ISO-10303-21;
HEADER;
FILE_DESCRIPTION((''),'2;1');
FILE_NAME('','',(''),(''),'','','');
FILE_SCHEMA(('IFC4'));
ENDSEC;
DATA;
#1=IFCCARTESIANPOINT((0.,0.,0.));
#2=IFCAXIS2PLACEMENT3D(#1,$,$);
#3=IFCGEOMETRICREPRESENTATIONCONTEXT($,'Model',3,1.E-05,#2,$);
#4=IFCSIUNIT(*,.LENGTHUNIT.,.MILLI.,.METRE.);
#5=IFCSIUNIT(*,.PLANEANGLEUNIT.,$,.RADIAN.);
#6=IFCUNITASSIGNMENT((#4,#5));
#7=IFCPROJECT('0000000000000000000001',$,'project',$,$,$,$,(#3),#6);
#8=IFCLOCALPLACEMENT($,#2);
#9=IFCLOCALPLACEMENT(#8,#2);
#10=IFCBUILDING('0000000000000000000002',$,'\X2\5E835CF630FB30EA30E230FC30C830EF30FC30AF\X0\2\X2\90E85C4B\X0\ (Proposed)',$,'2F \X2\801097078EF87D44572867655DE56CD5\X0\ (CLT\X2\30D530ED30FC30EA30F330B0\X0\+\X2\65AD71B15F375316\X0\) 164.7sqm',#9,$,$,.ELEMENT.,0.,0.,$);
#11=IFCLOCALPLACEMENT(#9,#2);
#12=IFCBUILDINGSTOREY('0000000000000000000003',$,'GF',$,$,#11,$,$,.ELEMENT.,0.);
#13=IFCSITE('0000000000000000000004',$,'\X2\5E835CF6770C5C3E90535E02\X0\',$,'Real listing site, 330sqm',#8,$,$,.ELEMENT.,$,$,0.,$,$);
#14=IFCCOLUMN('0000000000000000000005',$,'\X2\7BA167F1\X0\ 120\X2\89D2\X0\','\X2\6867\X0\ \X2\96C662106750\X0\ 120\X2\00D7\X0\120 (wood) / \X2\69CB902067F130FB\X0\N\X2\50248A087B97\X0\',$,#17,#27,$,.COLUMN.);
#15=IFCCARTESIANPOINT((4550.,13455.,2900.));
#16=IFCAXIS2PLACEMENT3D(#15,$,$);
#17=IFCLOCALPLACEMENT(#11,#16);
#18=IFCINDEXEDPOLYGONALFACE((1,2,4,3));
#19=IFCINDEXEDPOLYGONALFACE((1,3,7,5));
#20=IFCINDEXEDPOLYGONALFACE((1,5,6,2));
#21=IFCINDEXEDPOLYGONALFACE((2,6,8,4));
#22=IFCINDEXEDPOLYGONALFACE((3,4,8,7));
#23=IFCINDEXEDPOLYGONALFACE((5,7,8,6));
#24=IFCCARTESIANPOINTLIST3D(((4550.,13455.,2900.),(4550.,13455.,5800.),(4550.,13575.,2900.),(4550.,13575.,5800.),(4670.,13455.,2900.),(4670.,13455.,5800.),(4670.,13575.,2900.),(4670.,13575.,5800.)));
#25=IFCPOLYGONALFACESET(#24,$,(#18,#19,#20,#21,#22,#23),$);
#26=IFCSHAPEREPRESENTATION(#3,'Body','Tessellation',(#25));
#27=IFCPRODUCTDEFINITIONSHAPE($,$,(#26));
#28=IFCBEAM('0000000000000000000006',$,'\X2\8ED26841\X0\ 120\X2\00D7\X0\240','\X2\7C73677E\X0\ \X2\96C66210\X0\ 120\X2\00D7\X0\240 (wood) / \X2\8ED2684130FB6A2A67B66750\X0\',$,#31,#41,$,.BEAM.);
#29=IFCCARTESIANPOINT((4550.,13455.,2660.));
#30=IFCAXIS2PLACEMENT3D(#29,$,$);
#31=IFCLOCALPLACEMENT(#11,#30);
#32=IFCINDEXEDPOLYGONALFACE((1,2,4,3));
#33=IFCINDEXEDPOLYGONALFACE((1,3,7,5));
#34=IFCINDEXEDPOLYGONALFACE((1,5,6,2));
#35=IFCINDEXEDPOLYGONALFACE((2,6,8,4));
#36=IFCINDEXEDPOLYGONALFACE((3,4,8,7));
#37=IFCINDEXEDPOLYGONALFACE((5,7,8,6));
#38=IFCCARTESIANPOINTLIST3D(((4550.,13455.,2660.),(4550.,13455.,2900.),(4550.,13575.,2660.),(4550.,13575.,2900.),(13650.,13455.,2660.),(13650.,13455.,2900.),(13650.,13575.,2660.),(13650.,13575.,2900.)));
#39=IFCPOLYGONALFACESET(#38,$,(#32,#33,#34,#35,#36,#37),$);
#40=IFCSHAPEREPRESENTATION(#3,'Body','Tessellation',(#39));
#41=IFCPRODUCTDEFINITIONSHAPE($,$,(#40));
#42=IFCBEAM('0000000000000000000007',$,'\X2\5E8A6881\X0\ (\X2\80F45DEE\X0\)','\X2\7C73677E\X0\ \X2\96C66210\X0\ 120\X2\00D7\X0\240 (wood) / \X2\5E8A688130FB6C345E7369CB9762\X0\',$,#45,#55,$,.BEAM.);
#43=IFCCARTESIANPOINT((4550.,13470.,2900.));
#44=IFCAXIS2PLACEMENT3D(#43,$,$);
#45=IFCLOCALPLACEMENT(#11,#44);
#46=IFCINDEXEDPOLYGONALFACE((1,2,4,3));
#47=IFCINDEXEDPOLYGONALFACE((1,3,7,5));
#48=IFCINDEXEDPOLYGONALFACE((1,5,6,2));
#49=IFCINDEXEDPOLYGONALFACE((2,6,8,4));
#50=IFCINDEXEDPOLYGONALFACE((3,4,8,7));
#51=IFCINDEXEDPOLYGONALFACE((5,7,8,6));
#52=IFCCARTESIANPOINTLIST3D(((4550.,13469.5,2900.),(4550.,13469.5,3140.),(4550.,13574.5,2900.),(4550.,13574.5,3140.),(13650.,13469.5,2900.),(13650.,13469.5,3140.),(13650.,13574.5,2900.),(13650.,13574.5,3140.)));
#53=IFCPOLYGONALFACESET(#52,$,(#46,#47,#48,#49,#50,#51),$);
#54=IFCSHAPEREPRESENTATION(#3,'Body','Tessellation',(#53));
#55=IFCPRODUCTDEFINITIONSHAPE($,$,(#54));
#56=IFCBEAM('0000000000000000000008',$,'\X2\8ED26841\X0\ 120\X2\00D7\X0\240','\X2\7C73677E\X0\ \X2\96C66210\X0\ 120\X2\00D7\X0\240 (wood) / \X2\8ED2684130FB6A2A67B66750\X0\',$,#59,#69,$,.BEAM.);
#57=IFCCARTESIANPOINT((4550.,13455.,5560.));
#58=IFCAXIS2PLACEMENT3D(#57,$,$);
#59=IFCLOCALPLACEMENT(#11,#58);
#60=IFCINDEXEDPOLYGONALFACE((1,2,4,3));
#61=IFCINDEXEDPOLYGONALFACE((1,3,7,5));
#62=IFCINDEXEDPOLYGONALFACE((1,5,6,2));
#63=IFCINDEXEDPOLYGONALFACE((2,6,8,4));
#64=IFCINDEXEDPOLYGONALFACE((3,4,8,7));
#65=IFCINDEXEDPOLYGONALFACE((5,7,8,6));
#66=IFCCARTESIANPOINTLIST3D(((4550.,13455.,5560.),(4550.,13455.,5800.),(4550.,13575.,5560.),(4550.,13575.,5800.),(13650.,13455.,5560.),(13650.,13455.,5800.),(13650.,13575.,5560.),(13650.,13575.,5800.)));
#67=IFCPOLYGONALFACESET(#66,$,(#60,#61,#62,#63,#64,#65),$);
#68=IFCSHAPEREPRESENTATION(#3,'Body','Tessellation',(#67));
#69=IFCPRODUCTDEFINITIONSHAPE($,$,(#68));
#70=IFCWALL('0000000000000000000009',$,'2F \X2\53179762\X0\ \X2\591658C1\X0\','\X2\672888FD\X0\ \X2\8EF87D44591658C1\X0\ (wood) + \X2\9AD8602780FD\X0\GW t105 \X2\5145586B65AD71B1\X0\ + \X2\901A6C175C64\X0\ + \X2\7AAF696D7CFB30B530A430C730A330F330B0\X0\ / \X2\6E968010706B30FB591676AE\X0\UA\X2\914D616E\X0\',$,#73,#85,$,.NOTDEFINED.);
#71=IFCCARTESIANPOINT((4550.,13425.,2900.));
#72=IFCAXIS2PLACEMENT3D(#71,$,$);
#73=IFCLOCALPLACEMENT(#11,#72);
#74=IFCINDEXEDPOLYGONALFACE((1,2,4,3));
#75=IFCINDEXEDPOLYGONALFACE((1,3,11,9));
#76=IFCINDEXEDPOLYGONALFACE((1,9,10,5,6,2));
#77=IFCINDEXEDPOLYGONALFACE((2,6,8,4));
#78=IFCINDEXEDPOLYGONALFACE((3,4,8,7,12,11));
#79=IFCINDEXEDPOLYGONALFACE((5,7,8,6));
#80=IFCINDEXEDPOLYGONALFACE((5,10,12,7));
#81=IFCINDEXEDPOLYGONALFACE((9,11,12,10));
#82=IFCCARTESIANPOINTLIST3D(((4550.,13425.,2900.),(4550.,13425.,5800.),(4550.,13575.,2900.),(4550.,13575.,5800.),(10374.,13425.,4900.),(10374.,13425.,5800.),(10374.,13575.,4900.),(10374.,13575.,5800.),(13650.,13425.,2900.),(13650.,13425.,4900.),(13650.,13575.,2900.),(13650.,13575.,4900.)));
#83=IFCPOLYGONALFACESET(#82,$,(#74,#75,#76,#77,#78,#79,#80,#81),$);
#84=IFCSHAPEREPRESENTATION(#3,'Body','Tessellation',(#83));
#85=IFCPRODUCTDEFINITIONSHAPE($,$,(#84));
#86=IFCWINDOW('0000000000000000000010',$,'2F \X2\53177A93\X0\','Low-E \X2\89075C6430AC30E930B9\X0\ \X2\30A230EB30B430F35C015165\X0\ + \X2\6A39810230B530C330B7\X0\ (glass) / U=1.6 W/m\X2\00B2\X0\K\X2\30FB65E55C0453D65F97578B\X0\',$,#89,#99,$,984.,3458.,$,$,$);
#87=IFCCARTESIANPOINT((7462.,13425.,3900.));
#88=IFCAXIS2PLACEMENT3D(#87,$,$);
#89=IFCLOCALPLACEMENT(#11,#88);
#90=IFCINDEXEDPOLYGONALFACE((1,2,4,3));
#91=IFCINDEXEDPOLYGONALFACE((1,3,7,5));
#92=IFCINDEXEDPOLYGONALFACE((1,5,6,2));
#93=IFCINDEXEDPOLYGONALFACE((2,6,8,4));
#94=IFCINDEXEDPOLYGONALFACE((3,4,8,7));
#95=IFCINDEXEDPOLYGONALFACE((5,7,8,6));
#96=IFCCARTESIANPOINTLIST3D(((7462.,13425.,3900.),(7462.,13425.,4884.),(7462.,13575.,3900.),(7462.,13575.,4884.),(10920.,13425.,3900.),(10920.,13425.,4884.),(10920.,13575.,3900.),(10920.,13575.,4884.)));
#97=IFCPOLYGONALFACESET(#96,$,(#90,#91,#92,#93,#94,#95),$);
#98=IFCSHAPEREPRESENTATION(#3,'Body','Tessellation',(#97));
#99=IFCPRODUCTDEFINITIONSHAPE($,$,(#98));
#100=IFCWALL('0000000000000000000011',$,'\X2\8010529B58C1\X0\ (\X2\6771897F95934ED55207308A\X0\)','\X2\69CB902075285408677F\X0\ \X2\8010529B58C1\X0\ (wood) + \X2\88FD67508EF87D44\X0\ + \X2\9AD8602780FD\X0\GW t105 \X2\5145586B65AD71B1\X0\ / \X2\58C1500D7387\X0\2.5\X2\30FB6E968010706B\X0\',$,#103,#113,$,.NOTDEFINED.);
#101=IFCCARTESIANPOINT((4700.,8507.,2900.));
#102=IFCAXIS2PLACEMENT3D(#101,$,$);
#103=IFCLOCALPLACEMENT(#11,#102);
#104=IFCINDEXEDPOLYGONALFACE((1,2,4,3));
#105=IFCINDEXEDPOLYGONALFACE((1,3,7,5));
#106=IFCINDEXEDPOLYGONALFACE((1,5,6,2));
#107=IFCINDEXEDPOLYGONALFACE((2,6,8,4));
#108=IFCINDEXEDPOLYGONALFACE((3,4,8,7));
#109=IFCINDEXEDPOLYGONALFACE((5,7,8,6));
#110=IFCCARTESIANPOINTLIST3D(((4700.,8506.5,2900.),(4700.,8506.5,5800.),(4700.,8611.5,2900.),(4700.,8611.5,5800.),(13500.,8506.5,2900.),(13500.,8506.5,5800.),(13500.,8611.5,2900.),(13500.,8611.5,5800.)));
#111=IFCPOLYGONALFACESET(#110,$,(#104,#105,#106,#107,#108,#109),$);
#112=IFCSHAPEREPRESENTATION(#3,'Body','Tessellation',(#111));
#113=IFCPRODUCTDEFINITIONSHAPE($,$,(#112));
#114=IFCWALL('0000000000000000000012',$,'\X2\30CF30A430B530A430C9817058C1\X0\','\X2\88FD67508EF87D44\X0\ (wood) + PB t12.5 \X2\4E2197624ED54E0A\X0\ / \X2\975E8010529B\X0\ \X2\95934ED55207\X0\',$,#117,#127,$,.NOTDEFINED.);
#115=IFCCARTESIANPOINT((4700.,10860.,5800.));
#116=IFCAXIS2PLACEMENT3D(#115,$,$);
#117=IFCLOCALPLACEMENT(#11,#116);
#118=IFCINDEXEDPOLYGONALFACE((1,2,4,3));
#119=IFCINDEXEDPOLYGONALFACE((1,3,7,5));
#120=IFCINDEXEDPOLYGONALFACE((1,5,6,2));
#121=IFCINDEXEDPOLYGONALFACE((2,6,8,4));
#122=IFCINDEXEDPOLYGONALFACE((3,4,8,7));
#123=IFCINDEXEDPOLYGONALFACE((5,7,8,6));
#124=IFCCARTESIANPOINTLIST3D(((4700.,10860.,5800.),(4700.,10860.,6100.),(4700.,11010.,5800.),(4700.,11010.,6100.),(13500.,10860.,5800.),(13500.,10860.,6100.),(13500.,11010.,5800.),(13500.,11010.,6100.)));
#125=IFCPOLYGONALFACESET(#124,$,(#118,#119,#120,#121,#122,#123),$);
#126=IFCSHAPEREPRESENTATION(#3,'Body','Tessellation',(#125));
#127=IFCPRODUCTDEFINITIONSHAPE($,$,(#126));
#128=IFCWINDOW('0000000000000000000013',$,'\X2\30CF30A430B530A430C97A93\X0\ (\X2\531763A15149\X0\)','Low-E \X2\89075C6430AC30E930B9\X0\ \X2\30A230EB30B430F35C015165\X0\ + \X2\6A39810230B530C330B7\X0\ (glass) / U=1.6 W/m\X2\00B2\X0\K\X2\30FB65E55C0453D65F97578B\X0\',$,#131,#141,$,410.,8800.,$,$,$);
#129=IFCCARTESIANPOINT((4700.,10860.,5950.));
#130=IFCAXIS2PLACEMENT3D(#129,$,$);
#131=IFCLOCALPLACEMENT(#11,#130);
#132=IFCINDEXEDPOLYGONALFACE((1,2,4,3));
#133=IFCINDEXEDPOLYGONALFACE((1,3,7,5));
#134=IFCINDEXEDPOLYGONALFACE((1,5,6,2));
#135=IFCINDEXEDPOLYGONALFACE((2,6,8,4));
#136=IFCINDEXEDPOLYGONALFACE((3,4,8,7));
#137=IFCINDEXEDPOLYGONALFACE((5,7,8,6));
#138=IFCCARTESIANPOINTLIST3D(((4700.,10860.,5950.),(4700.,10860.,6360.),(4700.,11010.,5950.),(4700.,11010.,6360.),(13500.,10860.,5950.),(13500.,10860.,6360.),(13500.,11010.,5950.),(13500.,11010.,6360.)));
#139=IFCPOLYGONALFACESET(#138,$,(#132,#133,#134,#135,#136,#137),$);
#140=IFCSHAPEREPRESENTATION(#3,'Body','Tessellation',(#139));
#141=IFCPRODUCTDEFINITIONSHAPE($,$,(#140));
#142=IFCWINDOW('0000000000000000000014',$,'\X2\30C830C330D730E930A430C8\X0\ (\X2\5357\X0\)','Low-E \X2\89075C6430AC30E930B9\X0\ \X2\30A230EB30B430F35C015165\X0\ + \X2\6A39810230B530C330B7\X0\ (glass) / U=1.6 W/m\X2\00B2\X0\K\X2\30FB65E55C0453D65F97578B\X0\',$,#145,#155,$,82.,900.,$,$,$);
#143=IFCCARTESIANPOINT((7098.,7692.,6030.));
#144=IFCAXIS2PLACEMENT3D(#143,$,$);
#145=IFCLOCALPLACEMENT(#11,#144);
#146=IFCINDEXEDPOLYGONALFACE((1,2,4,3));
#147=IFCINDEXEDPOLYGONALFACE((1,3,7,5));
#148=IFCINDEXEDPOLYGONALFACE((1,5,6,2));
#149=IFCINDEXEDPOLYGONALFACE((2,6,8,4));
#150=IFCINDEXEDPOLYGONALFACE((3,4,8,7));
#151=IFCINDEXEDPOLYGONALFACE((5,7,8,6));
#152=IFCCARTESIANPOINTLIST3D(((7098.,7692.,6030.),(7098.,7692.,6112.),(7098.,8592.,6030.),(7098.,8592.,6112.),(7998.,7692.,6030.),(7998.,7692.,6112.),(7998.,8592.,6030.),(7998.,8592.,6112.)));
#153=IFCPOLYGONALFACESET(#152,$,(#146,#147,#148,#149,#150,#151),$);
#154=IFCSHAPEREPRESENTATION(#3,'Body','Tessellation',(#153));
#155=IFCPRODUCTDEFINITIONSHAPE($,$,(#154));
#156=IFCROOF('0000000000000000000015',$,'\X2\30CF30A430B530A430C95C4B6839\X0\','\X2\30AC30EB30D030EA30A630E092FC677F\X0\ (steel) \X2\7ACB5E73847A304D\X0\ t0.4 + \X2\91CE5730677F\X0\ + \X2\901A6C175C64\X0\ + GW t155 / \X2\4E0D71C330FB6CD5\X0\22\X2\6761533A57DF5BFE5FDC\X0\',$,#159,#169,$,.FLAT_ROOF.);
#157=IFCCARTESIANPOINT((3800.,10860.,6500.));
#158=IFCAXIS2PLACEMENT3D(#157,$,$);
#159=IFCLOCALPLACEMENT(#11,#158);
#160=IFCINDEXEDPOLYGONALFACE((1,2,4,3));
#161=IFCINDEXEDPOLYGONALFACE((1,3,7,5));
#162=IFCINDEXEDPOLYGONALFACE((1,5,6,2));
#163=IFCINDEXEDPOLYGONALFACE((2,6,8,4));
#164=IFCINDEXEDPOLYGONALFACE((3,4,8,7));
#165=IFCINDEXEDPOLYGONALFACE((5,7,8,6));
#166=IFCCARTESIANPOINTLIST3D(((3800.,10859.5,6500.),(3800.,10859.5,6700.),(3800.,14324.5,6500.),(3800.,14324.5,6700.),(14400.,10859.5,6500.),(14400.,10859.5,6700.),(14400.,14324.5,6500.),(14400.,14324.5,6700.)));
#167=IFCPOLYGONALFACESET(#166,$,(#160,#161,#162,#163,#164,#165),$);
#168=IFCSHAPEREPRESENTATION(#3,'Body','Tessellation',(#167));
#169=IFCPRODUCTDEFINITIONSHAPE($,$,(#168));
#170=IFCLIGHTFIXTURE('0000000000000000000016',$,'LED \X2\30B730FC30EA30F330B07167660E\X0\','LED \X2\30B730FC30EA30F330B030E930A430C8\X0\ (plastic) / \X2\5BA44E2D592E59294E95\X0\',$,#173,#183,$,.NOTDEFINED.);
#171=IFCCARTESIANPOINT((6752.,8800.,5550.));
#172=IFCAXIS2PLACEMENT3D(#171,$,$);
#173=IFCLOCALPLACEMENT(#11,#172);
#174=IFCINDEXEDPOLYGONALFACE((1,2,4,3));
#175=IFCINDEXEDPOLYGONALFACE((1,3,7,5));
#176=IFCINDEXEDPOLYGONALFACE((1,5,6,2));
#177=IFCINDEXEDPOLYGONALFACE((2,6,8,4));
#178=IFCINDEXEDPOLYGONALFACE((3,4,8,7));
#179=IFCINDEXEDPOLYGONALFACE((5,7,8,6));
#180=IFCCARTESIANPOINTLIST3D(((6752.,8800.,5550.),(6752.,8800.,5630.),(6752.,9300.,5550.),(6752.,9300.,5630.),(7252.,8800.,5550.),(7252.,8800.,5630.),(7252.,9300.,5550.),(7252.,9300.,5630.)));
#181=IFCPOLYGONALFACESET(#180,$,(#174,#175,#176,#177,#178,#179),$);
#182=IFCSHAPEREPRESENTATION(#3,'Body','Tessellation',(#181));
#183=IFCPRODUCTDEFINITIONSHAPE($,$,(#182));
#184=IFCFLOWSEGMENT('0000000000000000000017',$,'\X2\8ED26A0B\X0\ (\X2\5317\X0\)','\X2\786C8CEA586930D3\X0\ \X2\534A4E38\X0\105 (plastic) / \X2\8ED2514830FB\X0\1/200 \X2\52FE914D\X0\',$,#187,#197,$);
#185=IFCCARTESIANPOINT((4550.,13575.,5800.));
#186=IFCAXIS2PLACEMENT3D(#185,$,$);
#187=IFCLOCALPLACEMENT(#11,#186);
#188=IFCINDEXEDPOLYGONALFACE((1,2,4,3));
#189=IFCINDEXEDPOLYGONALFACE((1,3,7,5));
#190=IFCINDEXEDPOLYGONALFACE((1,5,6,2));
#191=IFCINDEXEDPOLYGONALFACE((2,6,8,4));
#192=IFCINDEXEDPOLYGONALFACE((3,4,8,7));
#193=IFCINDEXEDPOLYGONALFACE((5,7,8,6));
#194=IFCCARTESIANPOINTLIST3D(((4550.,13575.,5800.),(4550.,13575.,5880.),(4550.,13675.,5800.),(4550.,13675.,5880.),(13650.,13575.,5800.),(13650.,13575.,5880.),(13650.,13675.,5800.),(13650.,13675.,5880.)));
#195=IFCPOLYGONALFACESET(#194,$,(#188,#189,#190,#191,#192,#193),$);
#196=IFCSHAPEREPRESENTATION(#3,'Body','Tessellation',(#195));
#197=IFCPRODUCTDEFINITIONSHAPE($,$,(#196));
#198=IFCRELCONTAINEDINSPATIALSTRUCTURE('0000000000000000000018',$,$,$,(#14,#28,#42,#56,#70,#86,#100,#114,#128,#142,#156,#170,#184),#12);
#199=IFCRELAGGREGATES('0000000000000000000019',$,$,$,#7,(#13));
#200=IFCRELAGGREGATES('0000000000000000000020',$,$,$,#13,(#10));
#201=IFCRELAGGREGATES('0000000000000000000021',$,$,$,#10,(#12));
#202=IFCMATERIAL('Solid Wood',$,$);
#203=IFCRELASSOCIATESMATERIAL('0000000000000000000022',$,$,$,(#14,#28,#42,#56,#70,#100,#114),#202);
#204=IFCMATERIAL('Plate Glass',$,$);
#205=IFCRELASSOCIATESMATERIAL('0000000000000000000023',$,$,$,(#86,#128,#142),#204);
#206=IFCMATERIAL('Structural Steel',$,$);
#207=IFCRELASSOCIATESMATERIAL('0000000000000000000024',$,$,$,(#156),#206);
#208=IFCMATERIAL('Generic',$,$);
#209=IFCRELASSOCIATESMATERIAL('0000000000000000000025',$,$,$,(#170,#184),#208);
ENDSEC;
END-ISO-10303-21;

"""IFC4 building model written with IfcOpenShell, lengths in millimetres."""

from ifc_helpers import new_model, si_unit, frame, frame_2d, origin, place, context, project, spatial, rectangle, extrude, material, element, fill, save


model = new_model("IFC4")

# Units and contexts
model_context = context("Model", 3, precision=1e-05, world=origin())
ifc_project = project(units=[si_unit("LENGTHUNIT", "METRE", prefix="MILLI"), si_unit("PLANEANGLEUNIT", "RADIAN")], contexts=[model_context])

# Site, building, storey
site_placement = place(None, origin())
site = spatial("IfcSite", under=ifc_project, at=site_placement, Name="広島県尾道市", ObjectType="Real listing site, 330sqm", CompositionType="ELEMENT", RefElevation=0.0)
building_placement = place(site_placement, origin())
building = spatial("IfcBuilding", under=site, at=building_placement, Name="広島・リモートワーク2部屋 (Proposed)", ObjectType="2F 耐震軸組在来工法 (CLTフローリング+断熱強化) 164.7sqm", CompositionType="ELEMENT", ElevationOfRefHeight=0.0, ElevationOfTerrain=0.0)
storey_placement = place(building_placement, origin())
storey = spatial("IfcBuildingStorey", under=building, at=storey_placement, Name="GF", CompositionType="ELEMENT", Elevation=0.0)

# Column
ifc_material_1 = material(Name="Solid Wood")
column_1_placement = place(storey_placement, frame((4550.0, 13455.0, 2900.0)))
element("IfcColumn", 1, at=column_1_placement, inside=storey, material=ifc_material_1, Name="管柱 120角", Description="桧 集成材 120×120 (wood) / 構造柱・N値計算", PredefinedType="COLUMN", context=model_context, shape_type="SweptSolid", body=[
    extrude(rectangle(XDim=120.0, YDim=120.0, at=frame_2d((60.0, 60.0))), frame((4550.0, 13455.0, 2900.0)), (0.0, 0.0, 1.0), 2900.0),
])

# Beams
beam_1_placement = place(storey_placement, frame((4550.0, 13455.0, 2660.0)))
element("IfcBeam", 2, at=beam_1_placement, inside=storey, material=ifc_material_1, Name="軒桁 120×240", Description="米松 集成 120×240 (wood) / 軒桁・横架材", PredefinedType="BEAM", context=model_context, shape_type="SweptSolid", body=[
    extrude(rectangle(XDim=9100.0, YDim=120.0, at=frame_2d((4550.0, 60.0))), frame((4550.0, 13455.0, 2660.0)), (0.0, 0.0, 1.0), 240.0),
])
beam_2_placement = place(storey_placement, frame((4550.0, 13470.0, 2900.0)))
element("IfcBeam", 3, at=beam_2_placement, inside=storey, material=ifc_material_1, Name="床梁 (胴差)", Description="米松 集成 120×240 (wood) / 床梁・水平構面", PredefinedType="BEAM", context=model_context, shape_type="SweptSolid", body=[
    extrude(rectangle(XDim=9100.0, YDim=105.0, at=frame_2d((4550.0, 52.0))), frame((4550.0, 13470.0, 2900.0)), (0.0, 0.0, 1.0), 240.0),
])
beam_3_placement = place(storey_placement, frame((4550.0, 13455.0, 5560.0)))
element("IfcBeam", 4, at=beam_3_placement, inside=storey, material=ifc_material_1, Name="軒桁 120×240", Description="米松 集成 120×240 (wood) / 軒桁・横架材", PredefinedType="BEAM", context=model_context, shape_type="SweptSolid", body=[
    extrude(rectangle(XDim=9100.0, YDim=120.0, at=frame_2d((4550.0, 60.0))), frame((4550.0, 13455.0, 5560.0)), (0.0, 0.0, 1.0), 240.0),
])

# Wall, opening, window
wall_1_placement = place(storey_placement, frame((4550.0, 13425.0, 2900.0)))
wall_1 = element("IfcWall", 5, at=wall_1_placement, inside=storey, material=ifc_material_1, Name="2F 北面 外壁", Description="木製 軸組外壁 (wood) + 高性能GW t105 充填断熱 + 通気層 + 窯業系サイディング / 準耐火・外皮UA配慮", PredefinedType="NOTDEFINED", context=model_context, shape_type="SweptSolid", body=[
    extrude(rectangle(XDim=9100.0, YDim=150.0, at=frame_2d((4550.0, 75.0))), frame((4550.0, 13425.0, 2900.0)), (0.0, 0.0, 1.0), 2900.0),
])
opening_1_placement = place(storey_placement, frame((7462.0, 13425.0, 3900.0)))
opening_1 = element("IfcOpeningElement", 6, at=opening_1_placement, cuts=wall_1, PredefinedType="NOTDEFINED", context=model_context, shape_type="SweptSolid", body=[
    extrude(rectangle(XDim=3458.0, YDim=150.0, at=frame_2d((1729.0, 75.0))), frame((7462.0, 13425.0, 3900.0)), (0.0, 0.0, 1.0), 984.0),
])
ifc_material_2 = material(Name="Plate Glass")
window_1_placement = place(storey_placement, frame((7462.0, 13425.0, 3900.0)))
window_1 = element("IfcWindow", 7, at=window_1_placement, inside=storey, material=ifc_material_2, Name="2F 北窓", Description="Low-E 複層ガラス アルゴン封入 + 樹脂サッシ (glass) / U=1.6 W/m²K・日射取得型", OverallHeight=984.0, OverallWidth=3458.0, context=model_context, shape_type="SweptSolid", body=[
    extrude(rectangle(XDim=3458.0, YDim=150.0, at=frame_2d((1729.0, 75.0))), frame((7462.0, 13425.0, 3900.0)), (0.0, 0.0, 1.0), 984.0),
])
fill(opening_1, window_1)

# Wall
wall_2_placement = place(storey_placement, frame((4700.0, 8507.0, 2900.0)))
element("IfcWall", 8, at=wall_2_placement, inside=storey, material=ifc_material_1, Name="耐力壁 (東西間仕切り)", Description="構造用合板 耐力壁 (wood) + 製材軸組 + 高性能GW t105 充填断熱 / 壁倍率2.5・準耐火", PredefinedType="NOTDEFINED", context=model_context, shape_type="SweptSolid", body=[
    extrude(rectangle(XDim=8800.0, YDim=105.0, at=frame_2d((4400.0, 52.0))), frame((4700.0, 8507.0, 2900.0)), (0.0, 0.0, 1.0), 2900.0),
])

# Wall, opening, window
wall_3_placement = place(storey_placement, frame((4700.0, 10860.0, 5800.0)))
wall_3 = element("IfcWall", 9, at=wall_3_placement, inside=storey, material=ifc_material_1, Name="ハイサイド腰壁", Description="製材軸組 (wood) + PB t12.5 両面仕上 / 非耐力 間仕切", PredefinedType="NOTDEFINED", context=model_context, shape_type="SweptSolid", body=[
    extrude(rectangle(XDim=8800.0, YDim=150.0, at=frame_2d((4400.0, 75.0))), frame((4700.0, 10860.0, 5800.0)), (0.0, 0.0, 1.0), 700.0),
])
opening_2_placement = place(storey_placement, frame((4700.0, 10860.0, 5950.0)))
opening_2 = element("IfcOpeningElement", 10, at=opening_2_placement, cuts=wall_3, PredefinedType="NOTDEFINED", context=model_context, shape_type="SweptSolid", body=[
    extrude(rectangle(XDim=8800.0, YDim=150.0, at=frame_2d((4400.0, 75.0))), frame((4700.0, 10860.0, 5950.0)), (0.0, 0.0, 1.0), 410.0),
])
window_2_placement = place(storey_placement, frame((4700.0, 10860.0, 5950.0)))
window_2 = element("IfcWindow", 11, at=window_2_placement, inside=storey, material=ifc_material_2, Name="ハイサイド窓 (北採光)", Description="Low-E 複層ガラス アルゴン封入 + 樹脂サッシ (glass) / U=1.6 W/m²K・日射取得型", OverallHeight=410.0, OverallWidth=8800.0, context=model_context, shape_type="SweptSolid", body=[
    extrude(rectangle(XDim=8800.0, YDim=150.0, at=frame_2d((4400.0, 75.0))), frame((4700.0, 10860.0, 5950.0)), (0.0, 0.0, 1.0), 410.0),
])
fill(opening_2, window_2)

# Window
window_3_placement = place(storey_placement, frame((7098.0, 7692.0, 6030.0)))
element("IfcWindow", 12, at=window_3_placement, inside=storey, material=ifc_material_2, Name="トップライト (南)", Description="Low-E 複層ガラス アルゴン封入 + 樹脂サッシ (glass) / U=1.6 W/m²K・日射取得型", OverallHeight=82.0, OverallWidth=900.0, context=model_context, shape_type="SweptSolid", body=[
    extrude(rectangle(XDim=900.0, YDim=900.0, at=frame_2d((450.0, 450.0))), frame((7098.0, 7692.0, 6030.0)), (0.0, 0.0, 1.0), 82.0),
])

# Roof
ifc_material_3 = material(Name="Structural Steel")
roof_placement = place(storey_placement, frame((3800.0, 10860.0, 6500.0)))
element("IfcRoof", 13, at=roof_placement, inside=storey, material=ifc_material_3, Name="ハイサイド屋根", Description="ガルバリウム鋼板 (steel) 立平葺き t0.4 + 野地板 + 通気層 + GW t155 / 不燃・法22条区域対応", PredefinedType="FLAT_ROOF", context=model_context, shape_type="SweptSolid", body=[
    extrude(rectangle(XDim=10600.0, YDim=3465.0, at=frame_2d((5300.0, 1732.0))), frame((3800.0, 10860.0, 6500.0)), (0.0, 0.0, 1.0), 200.0),
])

# Light fixture
ifc_material_4 = material(Name="Generic")
light_fixture_placement = place(storey_placement, frame((6752.0, 8800.0, 5550.0)))
element("IfcLightFixture", 14, at=light_fixture_placement, inside=storey, material=ifc_material_4, Name="LED シーリング照明", Description="LED シーリングライト (plastic) / 室中央天井", PredefinedType="NOTDEFINED", context=model_context, shape_type="SweptSolid", body=[
    extrude(rectangle(XDim=500.0, YDim=500.0, at=frame_2d((250.0, 250.0))), frame((6752.0, 8800.0, 5550.0)), (0.0, 0.0, 1.0), 80.0),
])

# Flow segment
flow_segment_placement = place(storey_placement, frame((4550.0, 13575.0, 5800.0)))
element("IfcFlowSegment", 15, at=flow_segment_placement, inside=storey, material=ifc_material_4, Name="軒樋 (北)", Description="硬質塩ビ 半丸105 (plastic) / 軒先・1/200 勾配", context=model_context, shape_type="SweptSolid", body=[
    extrude(rectangle(XDim=9100.0, YDim=100.0, at=frame_2d((4550.0, 50.0))), frame((4550.0, 13575.0, 5800.0)), (0.0, 0.0, 1.0), 80.0),
])

save(model, "model.ifc")
